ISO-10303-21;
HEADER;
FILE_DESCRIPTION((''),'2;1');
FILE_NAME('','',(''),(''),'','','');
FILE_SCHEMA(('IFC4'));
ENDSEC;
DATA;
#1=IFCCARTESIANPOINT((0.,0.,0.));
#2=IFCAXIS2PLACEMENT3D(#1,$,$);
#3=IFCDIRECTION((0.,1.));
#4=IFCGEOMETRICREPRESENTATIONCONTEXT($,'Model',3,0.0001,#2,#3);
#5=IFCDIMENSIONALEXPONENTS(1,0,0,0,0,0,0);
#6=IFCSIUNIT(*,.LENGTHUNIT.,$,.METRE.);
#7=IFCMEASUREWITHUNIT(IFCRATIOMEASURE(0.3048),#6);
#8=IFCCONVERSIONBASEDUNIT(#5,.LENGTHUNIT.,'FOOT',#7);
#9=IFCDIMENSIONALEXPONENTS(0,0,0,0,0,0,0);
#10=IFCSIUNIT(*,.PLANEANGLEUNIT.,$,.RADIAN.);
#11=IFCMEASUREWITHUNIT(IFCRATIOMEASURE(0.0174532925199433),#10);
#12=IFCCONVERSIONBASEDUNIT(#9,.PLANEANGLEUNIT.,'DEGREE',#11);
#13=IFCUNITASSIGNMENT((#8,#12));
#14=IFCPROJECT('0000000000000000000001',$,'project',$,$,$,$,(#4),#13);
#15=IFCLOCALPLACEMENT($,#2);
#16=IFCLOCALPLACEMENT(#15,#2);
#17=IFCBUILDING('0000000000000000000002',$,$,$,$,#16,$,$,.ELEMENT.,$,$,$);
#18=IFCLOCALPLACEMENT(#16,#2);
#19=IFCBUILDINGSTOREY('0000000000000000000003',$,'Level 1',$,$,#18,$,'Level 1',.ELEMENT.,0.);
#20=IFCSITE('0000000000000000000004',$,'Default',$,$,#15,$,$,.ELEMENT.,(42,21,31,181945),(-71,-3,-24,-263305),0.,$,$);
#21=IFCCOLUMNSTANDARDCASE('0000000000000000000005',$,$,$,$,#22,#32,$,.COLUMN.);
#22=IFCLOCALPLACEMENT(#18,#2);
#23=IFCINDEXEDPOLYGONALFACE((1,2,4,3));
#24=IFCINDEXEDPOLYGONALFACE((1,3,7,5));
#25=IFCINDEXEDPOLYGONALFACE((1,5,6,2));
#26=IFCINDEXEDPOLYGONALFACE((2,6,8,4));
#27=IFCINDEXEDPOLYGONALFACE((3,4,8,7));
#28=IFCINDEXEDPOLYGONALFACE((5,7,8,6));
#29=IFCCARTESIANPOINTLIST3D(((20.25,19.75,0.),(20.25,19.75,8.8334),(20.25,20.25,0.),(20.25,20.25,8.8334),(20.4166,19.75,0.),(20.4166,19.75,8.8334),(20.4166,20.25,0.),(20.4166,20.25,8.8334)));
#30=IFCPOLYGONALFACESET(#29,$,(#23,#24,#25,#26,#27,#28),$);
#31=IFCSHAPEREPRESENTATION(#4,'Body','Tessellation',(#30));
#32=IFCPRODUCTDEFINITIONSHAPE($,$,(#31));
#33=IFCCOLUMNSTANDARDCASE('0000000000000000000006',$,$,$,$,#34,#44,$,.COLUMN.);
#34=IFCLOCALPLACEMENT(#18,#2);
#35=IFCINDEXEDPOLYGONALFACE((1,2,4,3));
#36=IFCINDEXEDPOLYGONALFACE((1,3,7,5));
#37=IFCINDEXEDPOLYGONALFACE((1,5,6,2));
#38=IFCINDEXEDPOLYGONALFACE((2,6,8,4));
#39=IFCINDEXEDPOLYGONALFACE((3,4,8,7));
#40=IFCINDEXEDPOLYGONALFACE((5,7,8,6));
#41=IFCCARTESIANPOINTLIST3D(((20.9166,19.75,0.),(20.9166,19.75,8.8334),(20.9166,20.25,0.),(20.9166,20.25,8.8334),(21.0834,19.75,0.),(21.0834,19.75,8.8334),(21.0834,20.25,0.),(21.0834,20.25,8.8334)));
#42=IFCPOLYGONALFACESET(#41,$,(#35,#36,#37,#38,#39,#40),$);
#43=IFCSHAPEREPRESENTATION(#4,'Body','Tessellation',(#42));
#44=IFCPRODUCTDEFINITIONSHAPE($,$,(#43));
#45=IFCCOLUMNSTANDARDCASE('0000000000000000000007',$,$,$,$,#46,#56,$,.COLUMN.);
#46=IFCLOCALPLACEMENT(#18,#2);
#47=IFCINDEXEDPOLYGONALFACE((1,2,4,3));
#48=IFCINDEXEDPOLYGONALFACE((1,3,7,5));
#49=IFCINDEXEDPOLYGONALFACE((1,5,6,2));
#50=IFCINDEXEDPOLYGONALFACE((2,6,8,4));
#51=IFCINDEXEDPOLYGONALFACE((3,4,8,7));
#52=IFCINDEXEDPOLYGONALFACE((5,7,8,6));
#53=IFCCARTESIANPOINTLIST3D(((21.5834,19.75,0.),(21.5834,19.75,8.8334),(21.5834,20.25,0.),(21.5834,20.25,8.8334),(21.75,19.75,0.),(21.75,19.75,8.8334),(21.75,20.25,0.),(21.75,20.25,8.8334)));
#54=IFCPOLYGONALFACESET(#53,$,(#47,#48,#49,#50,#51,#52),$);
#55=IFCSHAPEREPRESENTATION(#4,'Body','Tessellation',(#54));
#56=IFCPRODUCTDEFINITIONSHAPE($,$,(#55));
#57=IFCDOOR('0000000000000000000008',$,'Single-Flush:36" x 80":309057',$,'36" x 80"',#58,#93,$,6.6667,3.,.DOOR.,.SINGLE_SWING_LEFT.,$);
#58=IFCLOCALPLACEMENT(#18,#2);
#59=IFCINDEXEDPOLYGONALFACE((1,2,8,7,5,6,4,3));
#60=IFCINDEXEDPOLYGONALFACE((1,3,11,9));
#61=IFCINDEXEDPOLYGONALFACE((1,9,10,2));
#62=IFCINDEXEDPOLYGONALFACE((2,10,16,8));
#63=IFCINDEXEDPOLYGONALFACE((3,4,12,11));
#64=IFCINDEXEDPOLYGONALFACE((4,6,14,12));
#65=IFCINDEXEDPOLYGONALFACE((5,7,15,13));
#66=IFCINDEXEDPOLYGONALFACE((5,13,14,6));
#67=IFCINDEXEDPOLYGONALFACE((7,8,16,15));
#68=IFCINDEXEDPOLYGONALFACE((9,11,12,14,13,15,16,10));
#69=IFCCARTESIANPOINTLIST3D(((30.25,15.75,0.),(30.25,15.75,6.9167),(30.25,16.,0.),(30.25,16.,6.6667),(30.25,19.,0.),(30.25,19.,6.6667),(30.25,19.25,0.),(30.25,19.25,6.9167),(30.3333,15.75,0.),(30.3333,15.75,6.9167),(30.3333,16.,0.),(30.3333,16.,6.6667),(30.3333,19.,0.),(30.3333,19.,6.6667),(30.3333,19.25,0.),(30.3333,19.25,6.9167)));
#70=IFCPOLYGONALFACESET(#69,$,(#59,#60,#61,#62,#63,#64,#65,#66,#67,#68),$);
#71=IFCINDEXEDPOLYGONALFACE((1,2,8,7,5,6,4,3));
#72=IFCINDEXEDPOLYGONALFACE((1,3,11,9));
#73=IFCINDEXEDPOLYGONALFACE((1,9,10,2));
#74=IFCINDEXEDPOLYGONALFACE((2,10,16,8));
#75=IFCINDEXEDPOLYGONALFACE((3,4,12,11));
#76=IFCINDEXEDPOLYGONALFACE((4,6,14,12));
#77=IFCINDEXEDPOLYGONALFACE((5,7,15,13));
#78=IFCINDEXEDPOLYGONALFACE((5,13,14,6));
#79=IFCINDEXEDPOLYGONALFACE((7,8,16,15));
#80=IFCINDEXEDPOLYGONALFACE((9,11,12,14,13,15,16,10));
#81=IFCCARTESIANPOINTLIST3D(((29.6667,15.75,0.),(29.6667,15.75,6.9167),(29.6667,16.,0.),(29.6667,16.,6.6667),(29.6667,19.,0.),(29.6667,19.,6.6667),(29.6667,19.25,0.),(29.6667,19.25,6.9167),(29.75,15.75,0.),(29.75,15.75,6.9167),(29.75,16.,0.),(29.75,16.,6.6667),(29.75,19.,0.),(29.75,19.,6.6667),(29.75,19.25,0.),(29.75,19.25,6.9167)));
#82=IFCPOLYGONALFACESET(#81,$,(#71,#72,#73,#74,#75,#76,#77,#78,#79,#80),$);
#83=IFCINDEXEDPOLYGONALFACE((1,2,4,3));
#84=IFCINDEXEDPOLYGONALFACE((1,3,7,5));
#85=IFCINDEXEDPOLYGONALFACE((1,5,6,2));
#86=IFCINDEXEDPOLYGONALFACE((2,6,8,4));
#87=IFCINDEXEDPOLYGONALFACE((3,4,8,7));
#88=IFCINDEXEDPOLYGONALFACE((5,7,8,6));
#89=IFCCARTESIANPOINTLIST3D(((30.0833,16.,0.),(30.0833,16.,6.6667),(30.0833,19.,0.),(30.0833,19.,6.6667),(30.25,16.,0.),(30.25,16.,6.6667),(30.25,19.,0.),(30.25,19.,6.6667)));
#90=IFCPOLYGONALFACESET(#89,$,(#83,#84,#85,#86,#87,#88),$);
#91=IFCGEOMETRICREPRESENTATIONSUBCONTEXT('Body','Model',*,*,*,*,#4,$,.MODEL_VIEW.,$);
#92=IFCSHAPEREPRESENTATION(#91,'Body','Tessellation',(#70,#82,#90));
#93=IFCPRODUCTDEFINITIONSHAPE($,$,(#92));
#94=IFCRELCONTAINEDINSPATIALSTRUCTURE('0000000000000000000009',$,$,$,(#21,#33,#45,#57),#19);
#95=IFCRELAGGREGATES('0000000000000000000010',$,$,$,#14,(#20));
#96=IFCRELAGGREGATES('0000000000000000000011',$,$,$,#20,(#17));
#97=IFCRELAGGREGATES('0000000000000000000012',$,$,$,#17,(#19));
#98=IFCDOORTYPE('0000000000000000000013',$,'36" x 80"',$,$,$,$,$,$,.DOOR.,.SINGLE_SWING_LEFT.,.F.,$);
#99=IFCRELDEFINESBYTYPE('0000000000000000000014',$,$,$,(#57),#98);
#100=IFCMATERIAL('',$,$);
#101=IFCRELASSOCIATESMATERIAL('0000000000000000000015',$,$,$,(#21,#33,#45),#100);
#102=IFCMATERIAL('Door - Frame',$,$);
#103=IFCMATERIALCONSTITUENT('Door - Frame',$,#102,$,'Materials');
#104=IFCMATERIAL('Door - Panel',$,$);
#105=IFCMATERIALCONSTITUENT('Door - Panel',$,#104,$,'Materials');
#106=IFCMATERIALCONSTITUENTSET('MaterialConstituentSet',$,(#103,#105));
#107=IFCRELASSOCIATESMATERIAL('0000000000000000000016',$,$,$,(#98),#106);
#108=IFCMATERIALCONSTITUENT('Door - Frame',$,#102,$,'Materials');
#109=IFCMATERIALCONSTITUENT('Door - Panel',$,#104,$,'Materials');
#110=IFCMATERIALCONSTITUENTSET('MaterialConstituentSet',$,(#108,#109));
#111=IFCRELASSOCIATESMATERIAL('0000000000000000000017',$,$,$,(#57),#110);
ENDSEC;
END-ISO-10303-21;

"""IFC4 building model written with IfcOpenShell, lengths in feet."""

from ifc_helpers import new_model, entity, si_unit, converted_unit, direction, frame, origin, origin_2d_with_axis, place, context, subcontext, project, spatial, polyline, rectangle, outline, extrude, source, transform, mapped, material, constituent, constituent_set, type_object, type_shapes, element, save


model = new_model("IFC4")

# Units and contexts
model_context = context("Model", 3, precision=0.0001, world=origin(), true_north=direction((0.0, 1.0)))
body_context = subcontext(model_context, "Body", "Model", "MODEL_VIEW")
ifc_project = project(units=[converted_unit("LENGTHUNIT", "FOOT", entity("IfcRatioMeasure", 0.3048), si_unit("LENGTHUNIT", "METRE"), dimensions=[1, 0, 0, 0, 0, 0, 0]), converted_unit("PLANEANGLEUNIT", "DEGREE", entity("IfcRatioMeasure", 0.0174532925199433), si_unit("PLANEANGLEUNIT", "RADIAN"), dimensions=[0, 0, 0, 0, 0, 0, 0])], contexts=[model_context])

# Site, building, storey
site_placement = place(None, origin())
site = spatial("IfcSite", under=ifc_project, at=site_placement, Name="Default", CompositionType="ELEMENT", RefLatitude=(42, 21, 31, 181945), RefLongitude=(-71, -3, -24, -263305), RefElevation=0.0)
building_placement = place(site_placement, origin())
building = spatial("IfcBuilding", under=site, at=building_placement, CompositionType="ELEMENT")
storey_placement = place(building_placement, origin())
storey = spatial("IfcBuildingStorey", under=building, at=storey_placement, Name="Level 1", LongName="Level 1", CompositionType="ELEMENT", Elevation=0.0)

# Columns
ifc_material_1 = material(Name="")
placement_1 = place(storey_placement, frame((0.25, 20.0, 0.0)))
for number, where, z_axis, x_axis in (
    (1, (20.0833, 0.0, 0.0), (0.0, 0.0, 1.0), (1.0, 0.0, 0.0)),
    (2, (20.75, 0.0, 0.0), (0.0, 0.0, 1.0), (1.0, 0.0, 0.0)),
    (3, (21.4167, 0.0, 0.0), (0.0, 0.0, 1.0), (1.0, 0.0, 0.0)),
):
    element("IfcColumnStandardCase", number, at=place(placement_1, frame(where, z_axis=z_axis, x_axis=x_axis)), inside=storey, material=ifc_material_1, PredefinedType="COLUMN", context=model_context, shape_type="SweptSolid", body=[
        extrude(rectangle(XDim=0.1667, YDim=0.5), origin(), (0.0, 0.0, 1.0), 8.8334),
    ])
placement_2 = place(storey_placement, frame((30.0, 45.75, 0.0), z_axis=(0.0, 0.0, 1.0), x_axis=(0.0, -1.0, 0.0)))

# Door
ifc_material_2 = material(Name="Door - Frame")
ifc_constituent_1 = constituent(ifc_material_2, Name="Door - Frame", Category="Materials")
ifc_material_3 = material(Name="Door - Panel")
ifc_constituent_2 = constituent(ifc_material_3, Name="Door - Panel", Category="Materials")
ifc_constituent_set_1 = constituent_set(constituents=[ifc_constituent_1, ifc_constituent_2], Name="MaterialConstituentSet")
ifc_constituent_3 = constituent(ifc_material_2, Name="Door - Frame", Category="Materials")
ifc_constituent_4 = constituent(ifc_material_3, Name="Door - Panel", Category="Materials")
ifc_constituent_set_2 = constituent_set(constituents=[ifc_constituent_3, ifc_constituent_4], Name="MaterialConstituentSet")
door_type = type_object("IfcDoorType", Name="36\" x 80\"", OperationType="SINGLE_SWING_LEFT", ParameterTakesPrecedence=False, PredefinedType="DOOR", material=ifc_constituent_set_2)
shared_shape = source(origin(), body_context, "Body", "SweptSolid", [
    extrude(outline(polyline([(-1.75, -3.5208), (1.75, -3.5208), (1.75, 3.3958), (1.5, 3.3958), (1.5, -3.2708), (-1.5, -3.2708), (-1.5, 3.3958), (-1.75, 3.3958), (-1.75, -3.5208)])), frame((1.5, 0.5833, 3.3958), z_axis=(0.0, -1.0, 0.0), x_axis=(-1.0, 0.0, 0.0)), (0.0, 0.0, 1.0), 0.0833),
    extrude(outline(polyline([(-3.5208, -1.75), (3.3958, -1.75), (3.3958, -1.5), (-3.2708, -1.5), (-3.2708, 1.5), (3.3958, 1.5), (3.3958, 1.75), (-3.5208, 1.75), (-3.5208, -1.75)])), frame((1.5, 0.0, 3.3958), z_axis=(0.0, -1.0, 0.0), x_axis=(0.0, 0.0, -1.0)), (0.0, 0.0, 1.0), 0.0833),
    extrude(rectangle(XDim=3.0, YDim=0.1667, at=origin_2d_with_axis()), frame((1.5, 0.4167, 0.0)), (0.0, 0.0, 1.0), 6.6667),
])
type_shapes(door_type, [shared_shape])
placement_3 = place(placement_2, frame((26.75, -0.25, 0.0)))
door_placement = place(placement_3, origin())
element("IfcDoor", 4, at=door_placement, inside=storey, type_object=door_type, material=ifc_constituent_set_1, Name="Single-Flush:36\" x 80\":309057", ObjectType="36\" x 80\"", OperationType="SINGLE_SWING_LEFT", OverallHeight=6.6667, OverallWidth=3.0, PredefinedType="DOOR", context=body_context, shape_type="MappedRepresentation", body=[
    mapped(shared_shape, transform((0.0, 0.0, 0.0), scale=1.0)),
])

save(model, "model.ifc")
